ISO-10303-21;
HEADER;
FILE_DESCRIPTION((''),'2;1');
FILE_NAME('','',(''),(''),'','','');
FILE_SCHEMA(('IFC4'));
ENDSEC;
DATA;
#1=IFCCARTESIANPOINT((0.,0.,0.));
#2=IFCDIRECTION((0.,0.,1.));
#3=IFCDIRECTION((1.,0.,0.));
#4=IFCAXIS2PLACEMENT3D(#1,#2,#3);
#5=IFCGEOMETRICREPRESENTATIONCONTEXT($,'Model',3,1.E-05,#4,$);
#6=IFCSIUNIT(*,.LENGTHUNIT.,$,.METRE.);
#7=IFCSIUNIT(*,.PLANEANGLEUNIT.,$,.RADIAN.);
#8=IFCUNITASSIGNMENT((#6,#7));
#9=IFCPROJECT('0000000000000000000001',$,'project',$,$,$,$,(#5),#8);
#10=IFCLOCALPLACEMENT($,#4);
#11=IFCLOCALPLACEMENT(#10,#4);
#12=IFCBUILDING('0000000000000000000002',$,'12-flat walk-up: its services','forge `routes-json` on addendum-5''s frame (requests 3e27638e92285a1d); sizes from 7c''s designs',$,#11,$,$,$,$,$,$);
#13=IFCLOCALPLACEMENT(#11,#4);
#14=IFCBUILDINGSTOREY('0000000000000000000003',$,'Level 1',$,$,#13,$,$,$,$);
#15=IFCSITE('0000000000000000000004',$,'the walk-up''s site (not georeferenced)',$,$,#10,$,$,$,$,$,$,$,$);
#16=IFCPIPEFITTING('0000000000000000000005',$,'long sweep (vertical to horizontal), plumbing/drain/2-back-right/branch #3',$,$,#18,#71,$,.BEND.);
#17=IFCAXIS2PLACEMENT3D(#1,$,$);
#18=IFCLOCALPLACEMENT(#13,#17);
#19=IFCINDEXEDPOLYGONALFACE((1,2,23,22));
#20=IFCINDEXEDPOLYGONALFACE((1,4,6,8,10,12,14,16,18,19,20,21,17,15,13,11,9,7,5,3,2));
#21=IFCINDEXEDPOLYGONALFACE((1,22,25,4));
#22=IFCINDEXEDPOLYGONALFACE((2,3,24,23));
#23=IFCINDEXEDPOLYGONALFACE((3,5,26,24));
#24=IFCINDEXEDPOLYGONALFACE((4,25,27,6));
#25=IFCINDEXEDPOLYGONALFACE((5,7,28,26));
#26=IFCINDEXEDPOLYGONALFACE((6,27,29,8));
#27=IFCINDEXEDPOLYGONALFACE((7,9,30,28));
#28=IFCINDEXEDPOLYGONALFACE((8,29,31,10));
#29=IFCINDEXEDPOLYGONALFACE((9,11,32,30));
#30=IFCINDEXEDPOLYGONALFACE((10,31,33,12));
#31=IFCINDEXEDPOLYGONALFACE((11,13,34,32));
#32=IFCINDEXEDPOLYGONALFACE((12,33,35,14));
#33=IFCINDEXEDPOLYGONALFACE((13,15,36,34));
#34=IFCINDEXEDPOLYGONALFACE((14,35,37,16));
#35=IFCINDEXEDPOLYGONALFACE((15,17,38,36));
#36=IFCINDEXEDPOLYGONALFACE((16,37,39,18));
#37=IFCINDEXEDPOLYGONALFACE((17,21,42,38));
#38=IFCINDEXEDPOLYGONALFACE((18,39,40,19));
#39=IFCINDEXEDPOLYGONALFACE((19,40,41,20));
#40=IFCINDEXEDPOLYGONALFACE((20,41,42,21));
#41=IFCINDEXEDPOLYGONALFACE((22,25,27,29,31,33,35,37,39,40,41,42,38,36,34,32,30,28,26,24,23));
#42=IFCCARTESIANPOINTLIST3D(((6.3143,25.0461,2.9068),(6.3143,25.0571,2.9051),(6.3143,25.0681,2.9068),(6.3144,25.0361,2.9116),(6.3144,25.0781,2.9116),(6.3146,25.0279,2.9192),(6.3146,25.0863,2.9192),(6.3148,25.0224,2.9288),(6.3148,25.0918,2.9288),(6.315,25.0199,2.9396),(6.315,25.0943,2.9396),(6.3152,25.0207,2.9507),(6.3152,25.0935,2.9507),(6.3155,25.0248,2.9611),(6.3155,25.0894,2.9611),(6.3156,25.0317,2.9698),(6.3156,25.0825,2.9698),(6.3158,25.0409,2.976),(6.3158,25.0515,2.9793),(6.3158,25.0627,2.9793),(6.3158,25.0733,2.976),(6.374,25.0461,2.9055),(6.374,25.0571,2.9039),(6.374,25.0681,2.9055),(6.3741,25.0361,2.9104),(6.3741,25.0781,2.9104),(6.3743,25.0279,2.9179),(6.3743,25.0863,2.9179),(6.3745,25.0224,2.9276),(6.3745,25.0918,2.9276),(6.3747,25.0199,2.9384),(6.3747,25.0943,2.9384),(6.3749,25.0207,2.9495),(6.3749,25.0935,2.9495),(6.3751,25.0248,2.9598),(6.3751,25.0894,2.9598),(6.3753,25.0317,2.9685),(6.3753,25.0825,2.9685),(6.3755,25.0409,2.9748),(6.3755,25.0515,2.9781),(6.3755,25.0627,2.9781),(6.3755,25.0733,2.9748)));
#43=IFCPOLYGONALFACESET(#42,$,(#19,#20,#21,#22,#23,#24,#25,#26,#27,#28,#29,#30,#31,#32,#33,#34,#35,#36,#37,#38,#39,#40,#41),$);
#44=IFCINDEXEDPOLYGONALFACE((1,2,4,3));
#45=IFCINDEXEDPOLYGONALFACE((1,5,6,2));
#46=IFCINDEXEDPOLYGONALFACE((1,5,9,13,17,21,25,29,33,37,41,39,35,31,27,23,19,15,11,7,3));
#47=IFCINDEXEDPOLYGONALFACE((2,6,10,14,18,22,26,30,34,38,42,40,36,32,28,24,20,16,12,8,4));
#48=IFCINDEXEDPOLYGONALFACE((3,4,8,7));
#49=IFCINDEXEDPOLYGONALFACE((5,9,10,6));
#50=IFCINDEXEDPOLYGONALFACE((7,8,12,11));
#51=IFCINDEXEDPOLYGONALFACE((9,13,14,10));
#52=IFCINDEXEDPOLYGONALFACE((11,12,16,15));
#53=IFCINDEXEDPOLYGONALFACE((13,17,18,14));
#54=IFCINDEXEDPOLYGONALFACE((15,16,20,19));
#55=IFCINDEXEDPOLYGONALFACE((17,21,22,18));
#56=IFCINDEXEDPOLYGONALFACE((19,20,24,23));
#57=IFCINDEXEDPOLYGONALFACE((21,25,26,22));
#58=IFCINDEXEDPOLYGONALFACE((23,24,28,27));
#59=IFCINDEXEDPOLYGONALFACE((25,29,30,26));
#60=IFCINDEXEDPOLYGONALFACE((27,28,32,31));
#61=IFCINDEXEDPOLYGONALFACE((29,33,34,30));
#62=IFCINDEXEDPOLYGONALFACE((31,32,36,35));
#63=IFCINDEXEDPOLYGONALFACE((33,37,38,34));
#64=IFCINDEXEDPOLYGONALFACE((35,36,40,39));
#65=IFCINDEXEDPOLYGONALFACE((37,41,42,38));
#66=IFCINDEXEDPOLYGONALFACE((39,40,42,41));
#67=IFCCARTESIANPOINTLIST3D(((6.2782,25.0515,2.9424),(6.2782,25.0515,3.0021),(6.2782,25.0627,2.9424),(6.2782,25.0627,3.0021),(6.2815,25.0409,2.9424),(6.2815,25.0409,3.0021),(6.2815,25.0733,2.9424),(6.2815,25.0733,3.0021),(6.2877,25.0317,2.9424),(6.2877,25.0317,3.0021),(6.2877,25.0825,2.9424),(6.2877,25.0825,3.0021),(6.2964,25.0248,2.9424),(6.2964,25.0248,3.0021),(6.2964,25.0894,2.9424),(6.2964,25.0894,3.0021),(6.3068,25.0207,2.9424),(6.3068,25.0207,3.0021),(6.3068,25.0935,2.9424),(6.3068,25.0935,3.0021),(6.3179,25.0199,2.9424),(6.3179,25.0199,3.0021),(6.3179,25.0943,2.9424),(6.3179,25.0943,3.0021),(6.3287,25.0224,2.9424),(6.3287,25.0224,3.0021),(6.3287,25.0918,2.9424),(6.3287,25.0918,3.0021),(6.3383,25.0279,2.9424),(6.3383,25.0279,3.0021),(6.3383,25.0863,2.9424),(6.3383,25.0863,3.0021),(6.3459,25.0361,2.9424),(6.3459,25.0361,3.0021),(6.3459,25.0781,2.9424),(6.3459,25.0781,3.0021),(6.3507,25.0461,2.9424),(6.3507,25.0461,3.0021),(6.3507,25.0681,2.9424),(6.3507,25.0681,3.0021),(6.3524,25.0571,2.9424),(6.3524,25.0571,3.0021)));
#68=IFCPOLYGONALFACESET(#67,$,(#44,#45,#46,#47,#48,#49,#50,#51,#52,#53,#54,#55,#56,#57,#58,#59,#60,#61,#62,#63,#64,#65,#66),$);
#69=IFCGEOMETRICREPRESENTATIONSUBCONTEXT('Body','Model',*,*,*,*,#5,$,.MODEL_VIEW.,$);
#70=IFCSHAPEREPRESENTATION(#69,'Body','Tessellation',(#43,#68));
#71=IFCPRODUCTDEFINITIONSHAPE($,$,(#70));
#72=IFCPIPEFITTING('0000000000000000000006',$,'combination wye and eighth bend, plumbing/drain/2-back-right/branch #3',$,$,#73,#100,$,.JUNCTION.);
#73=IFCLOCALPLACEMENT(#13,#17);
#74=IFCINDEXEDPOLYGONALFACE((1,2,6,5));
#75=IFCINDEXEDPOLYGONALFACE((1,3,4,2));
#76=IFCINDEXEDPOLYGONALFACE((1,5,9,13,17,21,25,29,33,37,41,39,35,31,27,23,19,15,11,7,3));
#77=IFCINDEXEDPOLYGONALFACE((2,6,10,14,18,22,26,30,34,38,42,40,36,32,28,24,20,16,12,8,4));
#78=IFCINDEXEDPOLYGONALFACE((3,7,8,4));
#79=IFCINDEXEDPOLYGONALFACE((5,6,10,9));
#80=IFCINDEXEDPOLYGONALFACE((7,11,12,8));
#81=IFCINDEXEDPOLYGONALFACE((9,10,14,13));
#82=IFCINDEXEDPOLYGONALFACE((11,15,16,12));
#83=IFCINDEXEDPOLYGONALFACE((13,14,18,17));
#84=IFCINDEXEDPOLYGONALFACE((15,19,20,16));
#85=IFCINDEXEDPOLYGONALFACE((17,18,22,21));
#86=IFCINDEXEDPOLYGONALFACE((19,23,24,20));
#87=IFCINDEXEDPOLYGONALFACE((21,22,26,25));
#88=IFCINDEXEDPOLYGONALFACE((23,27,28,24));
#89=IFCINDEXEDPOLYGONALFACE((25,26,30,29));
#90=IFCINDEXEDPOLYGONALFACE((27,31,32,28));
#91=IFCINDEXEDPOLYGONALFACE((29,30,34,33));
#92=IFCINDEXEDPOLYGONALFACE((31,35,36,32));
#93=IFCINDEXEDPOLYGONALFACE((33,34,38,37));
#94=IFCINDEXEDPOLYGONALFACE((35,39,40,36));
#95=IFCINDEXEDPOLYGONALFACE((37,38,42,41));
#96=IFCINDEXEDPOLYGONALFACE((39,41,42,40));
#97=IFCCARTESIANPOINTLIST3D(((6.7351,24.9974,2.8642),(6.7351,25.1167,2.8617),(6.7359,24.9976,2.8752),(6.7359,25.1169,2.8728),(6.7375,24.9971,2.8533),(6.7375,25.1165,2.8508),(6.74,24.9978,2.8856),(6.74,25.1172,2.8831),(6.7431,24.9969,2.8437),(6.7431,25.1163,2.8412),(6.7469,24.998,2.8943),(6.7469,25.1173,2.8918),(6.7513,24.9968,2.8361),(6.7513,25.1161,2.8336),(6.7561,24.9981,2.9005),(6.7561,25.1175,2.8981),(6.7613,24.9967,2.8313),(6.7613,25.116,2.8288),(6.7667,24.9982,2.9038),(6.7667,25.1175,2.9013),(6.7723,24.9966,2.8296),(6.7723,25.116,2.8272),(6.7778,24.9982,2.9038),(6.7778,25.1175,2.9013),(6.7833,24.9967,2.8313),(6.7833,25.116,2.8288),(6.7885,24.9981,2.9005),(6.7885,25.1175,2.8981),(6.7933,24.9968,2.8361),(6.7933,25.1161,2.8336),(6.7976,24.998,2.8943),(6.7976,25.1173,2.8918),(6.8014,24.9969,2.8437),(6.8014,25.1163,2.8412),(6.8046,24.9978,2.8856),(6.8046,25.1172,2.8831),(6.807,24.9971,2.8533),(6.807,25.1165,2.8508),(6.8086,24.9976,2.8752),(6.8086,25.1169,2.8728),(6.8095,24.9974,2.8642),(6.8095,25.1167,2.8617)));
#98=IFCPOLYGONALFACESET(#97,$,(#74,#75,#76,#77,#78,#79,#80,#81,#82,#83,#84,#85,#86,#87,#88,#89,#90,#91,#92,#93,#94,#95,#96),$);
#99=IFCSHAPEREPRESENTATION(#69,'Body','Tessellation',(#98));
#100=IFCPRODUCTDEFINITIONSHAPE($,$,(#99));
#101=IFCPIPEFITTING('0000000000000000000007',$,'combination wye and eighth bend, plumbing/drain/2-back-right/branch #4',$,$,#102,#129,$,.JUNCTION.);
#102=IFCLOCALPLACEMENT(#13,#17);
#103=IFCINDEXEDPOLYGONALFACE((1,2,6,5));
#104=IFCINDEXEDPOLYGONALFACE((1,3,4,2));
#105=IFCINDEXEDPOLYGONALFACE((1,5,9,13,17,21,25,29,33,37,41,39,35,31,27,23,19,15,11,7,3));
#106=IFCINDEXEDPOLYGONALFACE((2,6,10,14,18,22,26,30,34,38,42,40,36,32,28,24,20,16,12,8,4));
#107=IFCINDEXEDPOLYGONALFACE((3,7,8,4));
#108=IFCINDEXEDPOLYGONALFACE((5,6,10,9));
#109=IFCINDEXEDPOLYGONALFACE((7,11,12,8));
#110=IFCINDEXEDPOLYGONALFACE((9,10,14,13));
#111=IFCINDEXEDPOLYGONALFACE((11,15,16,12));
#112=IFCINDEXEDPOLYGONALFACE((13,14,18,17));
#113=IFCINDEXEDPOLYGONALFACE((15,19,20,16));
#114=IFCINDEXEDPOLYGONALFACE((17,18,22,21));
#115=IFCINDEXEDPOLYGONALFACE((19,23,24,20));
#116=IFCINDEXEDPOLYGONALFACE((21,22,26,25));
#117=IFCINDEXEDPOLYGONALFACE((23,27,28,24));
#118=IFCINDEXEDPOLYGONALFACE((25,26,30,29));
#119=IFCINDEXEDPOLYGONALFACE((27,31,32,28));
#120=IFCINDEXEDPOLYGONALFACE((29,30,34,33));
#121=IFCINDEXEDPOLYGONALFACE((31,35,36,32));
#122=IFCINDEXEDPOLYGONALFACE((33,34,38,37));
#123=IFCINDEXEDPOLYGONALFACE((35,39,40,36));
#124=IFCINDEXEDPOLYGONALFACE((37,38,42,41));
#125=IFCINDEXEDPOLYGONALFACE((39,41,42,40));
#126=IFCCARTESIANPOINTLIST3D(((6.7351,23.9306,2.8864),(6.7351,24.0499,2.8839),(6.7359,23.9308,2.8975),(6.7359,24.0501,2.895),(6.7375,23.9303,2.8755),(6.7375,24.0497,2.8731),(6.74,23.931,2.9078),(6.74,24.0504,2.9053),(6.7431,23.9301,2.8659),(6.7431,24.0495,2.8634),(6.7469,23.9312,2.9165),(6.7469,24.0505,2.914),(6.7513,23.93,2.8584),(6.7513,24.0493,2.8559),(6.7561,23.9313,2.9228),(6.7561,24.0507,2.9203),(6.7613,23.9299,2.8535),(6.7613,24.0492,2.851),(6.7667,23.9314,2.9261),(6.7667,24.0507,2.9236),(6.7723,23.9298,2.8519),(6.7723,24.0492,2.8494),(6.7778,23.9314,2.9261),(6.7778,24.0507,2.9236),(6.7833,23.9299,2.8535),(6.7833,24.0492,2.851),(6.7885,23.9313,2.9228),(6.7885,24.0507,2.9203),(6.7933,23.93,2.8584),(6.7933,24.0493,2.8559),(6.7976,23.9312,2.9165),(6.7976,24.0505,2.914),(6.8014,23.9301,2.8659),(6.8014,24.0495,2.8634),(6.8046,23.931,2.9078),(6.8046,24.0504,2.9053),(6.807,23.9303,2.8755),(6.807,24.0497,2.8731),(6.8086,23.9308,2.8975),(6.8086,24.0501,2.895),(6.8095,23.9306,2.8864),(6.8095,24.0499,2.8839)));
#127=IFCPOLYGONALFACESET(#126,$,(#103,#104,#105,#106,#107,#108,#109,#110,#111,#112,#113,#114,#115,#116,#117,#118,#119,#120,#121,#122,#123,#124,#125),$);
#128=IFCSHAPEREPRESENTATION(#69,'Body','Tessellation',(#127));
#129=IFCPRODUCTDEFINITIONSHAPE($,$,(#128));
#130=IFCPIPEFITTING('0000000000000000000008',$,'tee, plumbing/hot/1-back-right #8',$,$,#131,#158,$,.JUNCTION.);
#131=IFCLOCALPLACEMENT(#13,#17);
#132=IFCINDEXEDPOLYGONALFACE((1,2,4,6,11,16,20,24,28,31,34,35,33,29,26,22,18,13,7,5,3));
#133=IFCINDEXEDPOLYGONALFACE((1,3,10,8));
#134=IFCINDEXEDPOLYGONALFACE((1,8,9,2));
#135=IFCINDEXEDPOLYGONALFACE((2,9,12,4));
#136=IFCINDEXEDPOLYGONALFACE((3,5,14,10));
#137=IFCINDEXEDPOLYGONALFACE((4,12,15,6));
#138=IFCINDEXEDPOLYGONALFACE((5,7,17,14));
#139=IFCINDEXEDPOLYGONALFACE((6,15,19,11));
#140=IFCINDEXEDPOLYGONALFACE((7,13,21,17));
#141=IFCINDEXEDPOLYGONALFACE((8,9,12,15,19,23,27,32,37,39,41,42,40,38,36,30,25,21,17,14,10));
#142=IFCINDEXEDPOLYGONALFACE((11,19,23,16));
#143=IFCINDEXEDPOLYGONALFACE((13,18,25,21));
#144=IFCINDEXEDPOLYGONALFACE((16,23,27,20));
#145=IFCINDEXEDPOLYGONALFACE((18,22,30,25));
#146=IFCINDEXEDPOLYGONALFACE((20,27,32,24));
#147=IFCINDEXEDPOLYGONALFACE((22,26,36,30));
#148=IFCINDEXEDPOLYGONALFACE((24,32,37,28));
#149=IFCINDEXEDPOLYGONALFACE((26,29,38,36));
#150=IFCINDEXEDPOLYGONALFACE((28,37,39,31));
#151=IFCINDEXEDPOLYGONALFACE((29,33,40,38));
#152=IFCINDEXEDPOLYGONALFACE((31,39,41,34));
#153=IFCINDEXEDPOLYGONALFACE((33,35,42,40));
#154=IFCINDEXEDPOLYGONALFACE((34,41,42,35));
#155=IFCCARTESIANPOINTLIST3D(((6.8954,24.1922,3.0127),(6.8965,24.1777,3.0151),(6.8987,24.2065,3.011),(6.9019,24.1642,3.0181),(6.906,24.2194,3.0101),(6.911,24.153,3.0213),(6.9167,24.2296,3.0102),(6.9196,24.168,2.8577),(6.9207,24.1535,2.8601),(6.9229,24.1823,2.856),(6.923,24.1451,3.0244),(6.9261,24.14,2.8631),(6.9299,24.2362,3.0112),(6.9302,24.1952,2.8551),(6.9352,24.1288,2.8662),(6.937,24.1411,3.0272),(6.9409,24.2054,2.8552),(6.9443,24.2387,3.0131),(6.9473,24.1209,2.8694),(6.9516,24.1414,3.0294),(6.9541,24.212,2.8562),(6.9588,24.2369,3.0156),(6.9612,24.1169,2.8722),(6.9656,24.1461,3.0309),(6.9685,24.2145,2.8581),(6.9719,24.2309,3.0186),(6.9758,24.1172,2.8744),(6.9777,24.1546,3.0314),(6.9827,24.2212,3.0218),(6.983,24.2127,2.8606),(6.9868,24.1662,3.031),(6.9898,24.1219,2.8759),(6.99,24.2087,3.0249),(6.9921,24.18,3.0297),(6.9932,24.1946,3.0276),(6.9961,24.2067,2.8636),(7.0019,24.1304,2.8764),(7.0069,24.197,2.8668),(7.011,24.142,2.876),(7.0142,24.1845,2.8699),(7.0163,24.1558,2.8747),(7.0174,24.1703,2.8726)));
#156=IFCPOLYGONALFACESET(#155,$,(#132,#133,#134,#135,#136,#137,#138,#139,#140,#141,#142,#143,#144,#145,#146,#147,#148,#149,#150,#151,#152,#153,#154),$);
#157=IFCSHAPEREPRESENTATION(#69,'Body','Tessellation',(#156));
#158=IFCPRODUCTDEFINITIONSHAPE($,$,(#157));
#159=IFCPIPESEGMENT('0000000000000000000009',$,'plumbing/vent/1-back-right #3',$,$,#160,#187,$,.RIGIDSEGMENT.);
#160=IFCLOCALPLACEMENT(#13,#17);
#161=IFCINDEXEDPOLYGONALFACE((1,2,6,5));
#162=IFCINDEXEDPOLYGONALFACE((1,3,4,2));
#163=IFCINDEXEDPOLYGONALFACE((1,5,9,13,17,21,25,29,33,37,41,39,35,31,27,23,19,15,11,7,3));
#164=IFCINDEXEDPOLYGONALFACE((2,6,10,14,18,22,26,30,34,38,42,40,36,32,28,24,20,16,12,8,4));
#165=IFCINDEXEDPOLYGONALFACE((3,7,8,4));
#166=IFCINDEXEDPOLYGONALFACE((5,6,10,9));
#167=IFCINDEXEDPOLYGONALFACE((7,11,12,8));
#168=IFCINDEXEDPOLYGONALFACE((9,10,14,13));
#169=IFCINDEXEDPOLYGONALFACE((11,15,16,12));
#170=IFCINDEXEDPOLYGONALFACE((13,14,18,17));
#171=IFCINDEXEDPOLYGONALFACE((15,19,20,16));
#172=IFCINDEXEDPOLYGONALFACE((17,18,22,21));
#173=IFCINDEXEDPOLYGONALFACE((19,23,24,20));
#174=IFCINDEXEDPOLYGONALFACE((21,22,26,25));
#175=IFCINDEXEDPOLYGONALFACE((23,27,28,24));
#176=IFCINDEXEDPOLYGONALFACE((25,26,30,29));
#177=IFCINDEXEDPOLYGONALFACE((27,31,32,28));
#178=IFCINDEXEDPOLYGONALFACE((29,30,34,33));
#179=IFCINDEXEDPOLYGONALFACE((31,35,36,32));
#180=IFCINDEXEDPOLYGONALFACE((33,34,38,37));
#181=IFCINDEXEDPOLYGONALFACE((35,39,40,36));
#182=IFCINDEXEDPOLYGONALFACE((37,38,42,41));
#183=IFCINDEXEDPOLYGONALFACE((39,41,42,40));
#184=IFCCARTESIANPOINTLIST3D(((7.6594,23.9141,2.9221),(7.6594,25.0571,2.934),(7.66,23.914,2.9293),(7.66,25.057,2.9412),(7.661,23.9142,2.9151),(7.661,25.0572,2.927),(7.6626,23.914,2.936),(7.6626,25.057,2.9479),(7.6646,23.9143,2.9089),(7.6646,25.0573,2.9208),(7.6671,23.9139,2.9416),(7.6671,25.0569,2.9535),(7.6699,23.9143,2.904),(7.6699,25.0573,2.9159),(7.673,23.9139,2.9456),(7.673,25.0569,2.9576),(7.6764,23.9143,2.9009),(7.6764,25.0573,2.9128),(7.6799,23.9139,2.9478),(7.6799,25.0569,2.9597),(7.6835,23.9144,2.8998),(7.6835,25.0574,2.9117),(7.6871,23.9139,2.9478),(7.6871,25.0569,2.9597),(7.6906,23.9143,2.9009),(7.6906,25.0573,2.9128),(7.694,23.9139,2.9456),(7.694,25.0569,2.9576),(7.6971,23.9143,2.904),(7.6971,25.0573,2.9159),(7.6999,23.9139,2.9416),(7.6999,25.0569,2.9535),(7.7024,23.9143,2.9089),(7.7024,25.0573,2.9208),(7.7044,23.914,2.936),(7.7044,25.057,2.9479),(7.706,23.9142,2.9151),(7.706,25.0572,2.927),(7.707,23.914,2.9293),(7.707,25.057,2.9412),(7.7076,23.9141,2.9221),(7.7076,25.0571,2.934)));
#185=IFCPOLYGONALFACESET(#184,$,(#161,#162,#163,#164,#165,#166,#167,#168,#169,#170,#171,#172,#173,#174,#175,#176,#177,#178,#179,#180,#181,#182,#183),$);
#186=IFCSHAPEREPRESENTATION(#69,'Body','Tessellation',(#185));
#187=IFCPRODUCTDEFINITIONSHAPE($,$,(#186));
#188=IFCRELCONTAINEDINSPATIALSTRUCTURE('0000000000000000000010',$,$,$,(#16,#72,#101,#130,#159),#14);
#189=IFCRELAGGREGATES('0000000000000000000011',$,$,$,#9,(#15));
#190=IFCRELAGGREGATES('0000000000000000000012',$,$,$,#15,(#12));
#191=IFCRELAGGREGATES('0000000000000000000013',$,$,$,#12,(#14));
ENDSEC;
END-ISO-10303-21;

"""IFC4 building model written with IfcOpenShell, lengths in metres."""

from ifc_helpers import new_model, entity, si_unit, frame, origin_with_axes, place, context, subcontext, project, spatial, element, save


model = new_model("IFC4")

# Units and contexts
model_context = context("Model", 3, precision=1e-05, world=origin_with_axes())
body_context = subcontext(model_context, "Body", "Model", "MODEL_VIEW")
ifc_project = project(units=[si_unit("LENGTHUNIT", "METRE"), si_unit("PLANEANGLEUNIT", "RADIAN")], contexts=[model_context])

# Site, building, storey
site_placement = place(None, origin_with_axes())
site = spatial("IfcSite", under=ifc_project, at=site_placement, Name="the walk-up's site (not georeferenced)")
building_placement = place(site_placement, origin_with_axes())
building = spatial("IfcBuilding", under=site, at=building_placement, Name="12-flat walk-up: its services", Description="forge `routes-json` on addendum-5's frame (requests 3e27638e92285a1d); sizes from 7c's designs")
storey_placement = place(building_placement, origin_with_axes())
storey = spatial("IfcBuildingStorey", under=building, at=storey_placement, Name="Level 1")

# Pipe fittings
pipe_fitting_1_placement = place(storey_placement, frame((6.3748, 25.0571, 2.9412), z_axis=(0.0, 0.0, 1.0), x_axis=(1.0, 0.0, 0.0)))
element("IfcPipeFitting", 1, at=pipe_fitting_1_placement, inside=storey, Name="long sweep (vertical to horizontal), plumbing/drain/2-back-right/branch #3", PredefinedType="BEND", context=body_context, shape_type="AdvancedSweptSolid", body=[
    entity("IfcSweptDiskSolid", entity("IfcPolyline", [entity("IfcCartesianPoint", [0.0, 0.0, 0.0]), entity("IfcCartesianPoint", [-0.0597, 0.0, 0.0012])]), 0.0373),
    entity("IfcSweptDiskSolid", entity("IfcPolyline", [entity("IfcCartesianPoint", [-0.0597, 0.0, 0.0012]), entity("IfcCartesianPoint", [-0.0597, 0.0, 0.0609])]), 0.0373),
])
pipe_fitting_2_placement = place(storey_placement, frame((6.7723, 25.1168, 2.8645), z_axis=(0.0, 0.0, 1.0), x_axis=(1.0, 0.0, 0.0)))
element("IfcPipeFitting", 2, at=pipe_fitting_2_placement, inside=storey, Name="combination wye and eighth bend, plumbing/drain/2-back-right/branch #3", PredefinedType="JUNCTION", context=body_context, shape_type="AdvancedSweptSolid", body=[
    entity("IfcSweptDiskSolid", entity("IfcPolyline", [entity("IfcCartesianPoint", [0.0, 0.0, 0.0]), entity("IfcCartesianPoint", [0.0, -0.1194, 0.0025])]), 0.0373),
])
pipe_fitting_3_placement = place(storey_placement, frame((6.7723, 24.05, 2.8867), z_axis=(0.0, 0.0, 1.0), x_axis=(1.0, 0.0, 0.0)))
element("IfcPipeFitting", 3, at=pipe_fitting_3_placement, inside=storey, Name="combination wye and eighth bend, plumbing/drain/2-back-right/branch #4", PredefinedType="JUNCTION", context=body_context, shape_type="AdvancedSweptSolid", body=[
    entity("IfcSweptDiskSolid", entity("IfcPolyline", [entity("IfcCartesianPoint", [0.0, 0.0, 0.0]), entity("IfcCartesianPoint", [0.0, -0.1194, 0.0025])]), 0.0373),
])

# Pipe fitting
pipe_fitting_4_placement = place(storey_placement, frame((6.9685, 24.1655, 2.8657), z_axis=(0.0, 0.0, 1.0), x_axis=(1.0, 0.0, 0.0)))
element("IfcPipeFitting", 4, at=pipe_fitting_4_placement, inside=storey, Name="tee, plumbing/hot/1-back-right #8", PredefinedType="JUNCTION", context=body_context, shape_type="AdvancedSweptSolid", body=[
    entity("IfcSweptDiskSolid", entity("IfcPolyline", [entity("IfcCartesianPoint", [0.0, 0.0, 0.0]), entity("IfcCartesianPoint", [-0.0242, 0.0242, 0.155])]), 0.0496),
])

# Pipe segment
pipe_segment_1_placement = place(storey_placement, frame((7.6835, 25.0571, 2.9358), z_axis=(0.0, 0.0, 1.0), x_axis=(1.0, 0.0, 0.0)))
element("IfcPipeSegment", 5, at=pipe_segment_1_placement, inside=storey, Name="plumbing/vent/1-back-right #3", PredefinedType="RIGIDSEGMENT", context=body_context, shape_type="AdvancedSweptSolid", body=[
    entity("IfcSweptDiskSolid", entity("IfcPolyline", [entity("IfcCartesianPoint", [0.0, 0.0, 0.0]), entity("IfcCartesianPoint", [0.0, -1.143, -0.0119])]), 0.0241),
])

save(model, "model.ifc")
